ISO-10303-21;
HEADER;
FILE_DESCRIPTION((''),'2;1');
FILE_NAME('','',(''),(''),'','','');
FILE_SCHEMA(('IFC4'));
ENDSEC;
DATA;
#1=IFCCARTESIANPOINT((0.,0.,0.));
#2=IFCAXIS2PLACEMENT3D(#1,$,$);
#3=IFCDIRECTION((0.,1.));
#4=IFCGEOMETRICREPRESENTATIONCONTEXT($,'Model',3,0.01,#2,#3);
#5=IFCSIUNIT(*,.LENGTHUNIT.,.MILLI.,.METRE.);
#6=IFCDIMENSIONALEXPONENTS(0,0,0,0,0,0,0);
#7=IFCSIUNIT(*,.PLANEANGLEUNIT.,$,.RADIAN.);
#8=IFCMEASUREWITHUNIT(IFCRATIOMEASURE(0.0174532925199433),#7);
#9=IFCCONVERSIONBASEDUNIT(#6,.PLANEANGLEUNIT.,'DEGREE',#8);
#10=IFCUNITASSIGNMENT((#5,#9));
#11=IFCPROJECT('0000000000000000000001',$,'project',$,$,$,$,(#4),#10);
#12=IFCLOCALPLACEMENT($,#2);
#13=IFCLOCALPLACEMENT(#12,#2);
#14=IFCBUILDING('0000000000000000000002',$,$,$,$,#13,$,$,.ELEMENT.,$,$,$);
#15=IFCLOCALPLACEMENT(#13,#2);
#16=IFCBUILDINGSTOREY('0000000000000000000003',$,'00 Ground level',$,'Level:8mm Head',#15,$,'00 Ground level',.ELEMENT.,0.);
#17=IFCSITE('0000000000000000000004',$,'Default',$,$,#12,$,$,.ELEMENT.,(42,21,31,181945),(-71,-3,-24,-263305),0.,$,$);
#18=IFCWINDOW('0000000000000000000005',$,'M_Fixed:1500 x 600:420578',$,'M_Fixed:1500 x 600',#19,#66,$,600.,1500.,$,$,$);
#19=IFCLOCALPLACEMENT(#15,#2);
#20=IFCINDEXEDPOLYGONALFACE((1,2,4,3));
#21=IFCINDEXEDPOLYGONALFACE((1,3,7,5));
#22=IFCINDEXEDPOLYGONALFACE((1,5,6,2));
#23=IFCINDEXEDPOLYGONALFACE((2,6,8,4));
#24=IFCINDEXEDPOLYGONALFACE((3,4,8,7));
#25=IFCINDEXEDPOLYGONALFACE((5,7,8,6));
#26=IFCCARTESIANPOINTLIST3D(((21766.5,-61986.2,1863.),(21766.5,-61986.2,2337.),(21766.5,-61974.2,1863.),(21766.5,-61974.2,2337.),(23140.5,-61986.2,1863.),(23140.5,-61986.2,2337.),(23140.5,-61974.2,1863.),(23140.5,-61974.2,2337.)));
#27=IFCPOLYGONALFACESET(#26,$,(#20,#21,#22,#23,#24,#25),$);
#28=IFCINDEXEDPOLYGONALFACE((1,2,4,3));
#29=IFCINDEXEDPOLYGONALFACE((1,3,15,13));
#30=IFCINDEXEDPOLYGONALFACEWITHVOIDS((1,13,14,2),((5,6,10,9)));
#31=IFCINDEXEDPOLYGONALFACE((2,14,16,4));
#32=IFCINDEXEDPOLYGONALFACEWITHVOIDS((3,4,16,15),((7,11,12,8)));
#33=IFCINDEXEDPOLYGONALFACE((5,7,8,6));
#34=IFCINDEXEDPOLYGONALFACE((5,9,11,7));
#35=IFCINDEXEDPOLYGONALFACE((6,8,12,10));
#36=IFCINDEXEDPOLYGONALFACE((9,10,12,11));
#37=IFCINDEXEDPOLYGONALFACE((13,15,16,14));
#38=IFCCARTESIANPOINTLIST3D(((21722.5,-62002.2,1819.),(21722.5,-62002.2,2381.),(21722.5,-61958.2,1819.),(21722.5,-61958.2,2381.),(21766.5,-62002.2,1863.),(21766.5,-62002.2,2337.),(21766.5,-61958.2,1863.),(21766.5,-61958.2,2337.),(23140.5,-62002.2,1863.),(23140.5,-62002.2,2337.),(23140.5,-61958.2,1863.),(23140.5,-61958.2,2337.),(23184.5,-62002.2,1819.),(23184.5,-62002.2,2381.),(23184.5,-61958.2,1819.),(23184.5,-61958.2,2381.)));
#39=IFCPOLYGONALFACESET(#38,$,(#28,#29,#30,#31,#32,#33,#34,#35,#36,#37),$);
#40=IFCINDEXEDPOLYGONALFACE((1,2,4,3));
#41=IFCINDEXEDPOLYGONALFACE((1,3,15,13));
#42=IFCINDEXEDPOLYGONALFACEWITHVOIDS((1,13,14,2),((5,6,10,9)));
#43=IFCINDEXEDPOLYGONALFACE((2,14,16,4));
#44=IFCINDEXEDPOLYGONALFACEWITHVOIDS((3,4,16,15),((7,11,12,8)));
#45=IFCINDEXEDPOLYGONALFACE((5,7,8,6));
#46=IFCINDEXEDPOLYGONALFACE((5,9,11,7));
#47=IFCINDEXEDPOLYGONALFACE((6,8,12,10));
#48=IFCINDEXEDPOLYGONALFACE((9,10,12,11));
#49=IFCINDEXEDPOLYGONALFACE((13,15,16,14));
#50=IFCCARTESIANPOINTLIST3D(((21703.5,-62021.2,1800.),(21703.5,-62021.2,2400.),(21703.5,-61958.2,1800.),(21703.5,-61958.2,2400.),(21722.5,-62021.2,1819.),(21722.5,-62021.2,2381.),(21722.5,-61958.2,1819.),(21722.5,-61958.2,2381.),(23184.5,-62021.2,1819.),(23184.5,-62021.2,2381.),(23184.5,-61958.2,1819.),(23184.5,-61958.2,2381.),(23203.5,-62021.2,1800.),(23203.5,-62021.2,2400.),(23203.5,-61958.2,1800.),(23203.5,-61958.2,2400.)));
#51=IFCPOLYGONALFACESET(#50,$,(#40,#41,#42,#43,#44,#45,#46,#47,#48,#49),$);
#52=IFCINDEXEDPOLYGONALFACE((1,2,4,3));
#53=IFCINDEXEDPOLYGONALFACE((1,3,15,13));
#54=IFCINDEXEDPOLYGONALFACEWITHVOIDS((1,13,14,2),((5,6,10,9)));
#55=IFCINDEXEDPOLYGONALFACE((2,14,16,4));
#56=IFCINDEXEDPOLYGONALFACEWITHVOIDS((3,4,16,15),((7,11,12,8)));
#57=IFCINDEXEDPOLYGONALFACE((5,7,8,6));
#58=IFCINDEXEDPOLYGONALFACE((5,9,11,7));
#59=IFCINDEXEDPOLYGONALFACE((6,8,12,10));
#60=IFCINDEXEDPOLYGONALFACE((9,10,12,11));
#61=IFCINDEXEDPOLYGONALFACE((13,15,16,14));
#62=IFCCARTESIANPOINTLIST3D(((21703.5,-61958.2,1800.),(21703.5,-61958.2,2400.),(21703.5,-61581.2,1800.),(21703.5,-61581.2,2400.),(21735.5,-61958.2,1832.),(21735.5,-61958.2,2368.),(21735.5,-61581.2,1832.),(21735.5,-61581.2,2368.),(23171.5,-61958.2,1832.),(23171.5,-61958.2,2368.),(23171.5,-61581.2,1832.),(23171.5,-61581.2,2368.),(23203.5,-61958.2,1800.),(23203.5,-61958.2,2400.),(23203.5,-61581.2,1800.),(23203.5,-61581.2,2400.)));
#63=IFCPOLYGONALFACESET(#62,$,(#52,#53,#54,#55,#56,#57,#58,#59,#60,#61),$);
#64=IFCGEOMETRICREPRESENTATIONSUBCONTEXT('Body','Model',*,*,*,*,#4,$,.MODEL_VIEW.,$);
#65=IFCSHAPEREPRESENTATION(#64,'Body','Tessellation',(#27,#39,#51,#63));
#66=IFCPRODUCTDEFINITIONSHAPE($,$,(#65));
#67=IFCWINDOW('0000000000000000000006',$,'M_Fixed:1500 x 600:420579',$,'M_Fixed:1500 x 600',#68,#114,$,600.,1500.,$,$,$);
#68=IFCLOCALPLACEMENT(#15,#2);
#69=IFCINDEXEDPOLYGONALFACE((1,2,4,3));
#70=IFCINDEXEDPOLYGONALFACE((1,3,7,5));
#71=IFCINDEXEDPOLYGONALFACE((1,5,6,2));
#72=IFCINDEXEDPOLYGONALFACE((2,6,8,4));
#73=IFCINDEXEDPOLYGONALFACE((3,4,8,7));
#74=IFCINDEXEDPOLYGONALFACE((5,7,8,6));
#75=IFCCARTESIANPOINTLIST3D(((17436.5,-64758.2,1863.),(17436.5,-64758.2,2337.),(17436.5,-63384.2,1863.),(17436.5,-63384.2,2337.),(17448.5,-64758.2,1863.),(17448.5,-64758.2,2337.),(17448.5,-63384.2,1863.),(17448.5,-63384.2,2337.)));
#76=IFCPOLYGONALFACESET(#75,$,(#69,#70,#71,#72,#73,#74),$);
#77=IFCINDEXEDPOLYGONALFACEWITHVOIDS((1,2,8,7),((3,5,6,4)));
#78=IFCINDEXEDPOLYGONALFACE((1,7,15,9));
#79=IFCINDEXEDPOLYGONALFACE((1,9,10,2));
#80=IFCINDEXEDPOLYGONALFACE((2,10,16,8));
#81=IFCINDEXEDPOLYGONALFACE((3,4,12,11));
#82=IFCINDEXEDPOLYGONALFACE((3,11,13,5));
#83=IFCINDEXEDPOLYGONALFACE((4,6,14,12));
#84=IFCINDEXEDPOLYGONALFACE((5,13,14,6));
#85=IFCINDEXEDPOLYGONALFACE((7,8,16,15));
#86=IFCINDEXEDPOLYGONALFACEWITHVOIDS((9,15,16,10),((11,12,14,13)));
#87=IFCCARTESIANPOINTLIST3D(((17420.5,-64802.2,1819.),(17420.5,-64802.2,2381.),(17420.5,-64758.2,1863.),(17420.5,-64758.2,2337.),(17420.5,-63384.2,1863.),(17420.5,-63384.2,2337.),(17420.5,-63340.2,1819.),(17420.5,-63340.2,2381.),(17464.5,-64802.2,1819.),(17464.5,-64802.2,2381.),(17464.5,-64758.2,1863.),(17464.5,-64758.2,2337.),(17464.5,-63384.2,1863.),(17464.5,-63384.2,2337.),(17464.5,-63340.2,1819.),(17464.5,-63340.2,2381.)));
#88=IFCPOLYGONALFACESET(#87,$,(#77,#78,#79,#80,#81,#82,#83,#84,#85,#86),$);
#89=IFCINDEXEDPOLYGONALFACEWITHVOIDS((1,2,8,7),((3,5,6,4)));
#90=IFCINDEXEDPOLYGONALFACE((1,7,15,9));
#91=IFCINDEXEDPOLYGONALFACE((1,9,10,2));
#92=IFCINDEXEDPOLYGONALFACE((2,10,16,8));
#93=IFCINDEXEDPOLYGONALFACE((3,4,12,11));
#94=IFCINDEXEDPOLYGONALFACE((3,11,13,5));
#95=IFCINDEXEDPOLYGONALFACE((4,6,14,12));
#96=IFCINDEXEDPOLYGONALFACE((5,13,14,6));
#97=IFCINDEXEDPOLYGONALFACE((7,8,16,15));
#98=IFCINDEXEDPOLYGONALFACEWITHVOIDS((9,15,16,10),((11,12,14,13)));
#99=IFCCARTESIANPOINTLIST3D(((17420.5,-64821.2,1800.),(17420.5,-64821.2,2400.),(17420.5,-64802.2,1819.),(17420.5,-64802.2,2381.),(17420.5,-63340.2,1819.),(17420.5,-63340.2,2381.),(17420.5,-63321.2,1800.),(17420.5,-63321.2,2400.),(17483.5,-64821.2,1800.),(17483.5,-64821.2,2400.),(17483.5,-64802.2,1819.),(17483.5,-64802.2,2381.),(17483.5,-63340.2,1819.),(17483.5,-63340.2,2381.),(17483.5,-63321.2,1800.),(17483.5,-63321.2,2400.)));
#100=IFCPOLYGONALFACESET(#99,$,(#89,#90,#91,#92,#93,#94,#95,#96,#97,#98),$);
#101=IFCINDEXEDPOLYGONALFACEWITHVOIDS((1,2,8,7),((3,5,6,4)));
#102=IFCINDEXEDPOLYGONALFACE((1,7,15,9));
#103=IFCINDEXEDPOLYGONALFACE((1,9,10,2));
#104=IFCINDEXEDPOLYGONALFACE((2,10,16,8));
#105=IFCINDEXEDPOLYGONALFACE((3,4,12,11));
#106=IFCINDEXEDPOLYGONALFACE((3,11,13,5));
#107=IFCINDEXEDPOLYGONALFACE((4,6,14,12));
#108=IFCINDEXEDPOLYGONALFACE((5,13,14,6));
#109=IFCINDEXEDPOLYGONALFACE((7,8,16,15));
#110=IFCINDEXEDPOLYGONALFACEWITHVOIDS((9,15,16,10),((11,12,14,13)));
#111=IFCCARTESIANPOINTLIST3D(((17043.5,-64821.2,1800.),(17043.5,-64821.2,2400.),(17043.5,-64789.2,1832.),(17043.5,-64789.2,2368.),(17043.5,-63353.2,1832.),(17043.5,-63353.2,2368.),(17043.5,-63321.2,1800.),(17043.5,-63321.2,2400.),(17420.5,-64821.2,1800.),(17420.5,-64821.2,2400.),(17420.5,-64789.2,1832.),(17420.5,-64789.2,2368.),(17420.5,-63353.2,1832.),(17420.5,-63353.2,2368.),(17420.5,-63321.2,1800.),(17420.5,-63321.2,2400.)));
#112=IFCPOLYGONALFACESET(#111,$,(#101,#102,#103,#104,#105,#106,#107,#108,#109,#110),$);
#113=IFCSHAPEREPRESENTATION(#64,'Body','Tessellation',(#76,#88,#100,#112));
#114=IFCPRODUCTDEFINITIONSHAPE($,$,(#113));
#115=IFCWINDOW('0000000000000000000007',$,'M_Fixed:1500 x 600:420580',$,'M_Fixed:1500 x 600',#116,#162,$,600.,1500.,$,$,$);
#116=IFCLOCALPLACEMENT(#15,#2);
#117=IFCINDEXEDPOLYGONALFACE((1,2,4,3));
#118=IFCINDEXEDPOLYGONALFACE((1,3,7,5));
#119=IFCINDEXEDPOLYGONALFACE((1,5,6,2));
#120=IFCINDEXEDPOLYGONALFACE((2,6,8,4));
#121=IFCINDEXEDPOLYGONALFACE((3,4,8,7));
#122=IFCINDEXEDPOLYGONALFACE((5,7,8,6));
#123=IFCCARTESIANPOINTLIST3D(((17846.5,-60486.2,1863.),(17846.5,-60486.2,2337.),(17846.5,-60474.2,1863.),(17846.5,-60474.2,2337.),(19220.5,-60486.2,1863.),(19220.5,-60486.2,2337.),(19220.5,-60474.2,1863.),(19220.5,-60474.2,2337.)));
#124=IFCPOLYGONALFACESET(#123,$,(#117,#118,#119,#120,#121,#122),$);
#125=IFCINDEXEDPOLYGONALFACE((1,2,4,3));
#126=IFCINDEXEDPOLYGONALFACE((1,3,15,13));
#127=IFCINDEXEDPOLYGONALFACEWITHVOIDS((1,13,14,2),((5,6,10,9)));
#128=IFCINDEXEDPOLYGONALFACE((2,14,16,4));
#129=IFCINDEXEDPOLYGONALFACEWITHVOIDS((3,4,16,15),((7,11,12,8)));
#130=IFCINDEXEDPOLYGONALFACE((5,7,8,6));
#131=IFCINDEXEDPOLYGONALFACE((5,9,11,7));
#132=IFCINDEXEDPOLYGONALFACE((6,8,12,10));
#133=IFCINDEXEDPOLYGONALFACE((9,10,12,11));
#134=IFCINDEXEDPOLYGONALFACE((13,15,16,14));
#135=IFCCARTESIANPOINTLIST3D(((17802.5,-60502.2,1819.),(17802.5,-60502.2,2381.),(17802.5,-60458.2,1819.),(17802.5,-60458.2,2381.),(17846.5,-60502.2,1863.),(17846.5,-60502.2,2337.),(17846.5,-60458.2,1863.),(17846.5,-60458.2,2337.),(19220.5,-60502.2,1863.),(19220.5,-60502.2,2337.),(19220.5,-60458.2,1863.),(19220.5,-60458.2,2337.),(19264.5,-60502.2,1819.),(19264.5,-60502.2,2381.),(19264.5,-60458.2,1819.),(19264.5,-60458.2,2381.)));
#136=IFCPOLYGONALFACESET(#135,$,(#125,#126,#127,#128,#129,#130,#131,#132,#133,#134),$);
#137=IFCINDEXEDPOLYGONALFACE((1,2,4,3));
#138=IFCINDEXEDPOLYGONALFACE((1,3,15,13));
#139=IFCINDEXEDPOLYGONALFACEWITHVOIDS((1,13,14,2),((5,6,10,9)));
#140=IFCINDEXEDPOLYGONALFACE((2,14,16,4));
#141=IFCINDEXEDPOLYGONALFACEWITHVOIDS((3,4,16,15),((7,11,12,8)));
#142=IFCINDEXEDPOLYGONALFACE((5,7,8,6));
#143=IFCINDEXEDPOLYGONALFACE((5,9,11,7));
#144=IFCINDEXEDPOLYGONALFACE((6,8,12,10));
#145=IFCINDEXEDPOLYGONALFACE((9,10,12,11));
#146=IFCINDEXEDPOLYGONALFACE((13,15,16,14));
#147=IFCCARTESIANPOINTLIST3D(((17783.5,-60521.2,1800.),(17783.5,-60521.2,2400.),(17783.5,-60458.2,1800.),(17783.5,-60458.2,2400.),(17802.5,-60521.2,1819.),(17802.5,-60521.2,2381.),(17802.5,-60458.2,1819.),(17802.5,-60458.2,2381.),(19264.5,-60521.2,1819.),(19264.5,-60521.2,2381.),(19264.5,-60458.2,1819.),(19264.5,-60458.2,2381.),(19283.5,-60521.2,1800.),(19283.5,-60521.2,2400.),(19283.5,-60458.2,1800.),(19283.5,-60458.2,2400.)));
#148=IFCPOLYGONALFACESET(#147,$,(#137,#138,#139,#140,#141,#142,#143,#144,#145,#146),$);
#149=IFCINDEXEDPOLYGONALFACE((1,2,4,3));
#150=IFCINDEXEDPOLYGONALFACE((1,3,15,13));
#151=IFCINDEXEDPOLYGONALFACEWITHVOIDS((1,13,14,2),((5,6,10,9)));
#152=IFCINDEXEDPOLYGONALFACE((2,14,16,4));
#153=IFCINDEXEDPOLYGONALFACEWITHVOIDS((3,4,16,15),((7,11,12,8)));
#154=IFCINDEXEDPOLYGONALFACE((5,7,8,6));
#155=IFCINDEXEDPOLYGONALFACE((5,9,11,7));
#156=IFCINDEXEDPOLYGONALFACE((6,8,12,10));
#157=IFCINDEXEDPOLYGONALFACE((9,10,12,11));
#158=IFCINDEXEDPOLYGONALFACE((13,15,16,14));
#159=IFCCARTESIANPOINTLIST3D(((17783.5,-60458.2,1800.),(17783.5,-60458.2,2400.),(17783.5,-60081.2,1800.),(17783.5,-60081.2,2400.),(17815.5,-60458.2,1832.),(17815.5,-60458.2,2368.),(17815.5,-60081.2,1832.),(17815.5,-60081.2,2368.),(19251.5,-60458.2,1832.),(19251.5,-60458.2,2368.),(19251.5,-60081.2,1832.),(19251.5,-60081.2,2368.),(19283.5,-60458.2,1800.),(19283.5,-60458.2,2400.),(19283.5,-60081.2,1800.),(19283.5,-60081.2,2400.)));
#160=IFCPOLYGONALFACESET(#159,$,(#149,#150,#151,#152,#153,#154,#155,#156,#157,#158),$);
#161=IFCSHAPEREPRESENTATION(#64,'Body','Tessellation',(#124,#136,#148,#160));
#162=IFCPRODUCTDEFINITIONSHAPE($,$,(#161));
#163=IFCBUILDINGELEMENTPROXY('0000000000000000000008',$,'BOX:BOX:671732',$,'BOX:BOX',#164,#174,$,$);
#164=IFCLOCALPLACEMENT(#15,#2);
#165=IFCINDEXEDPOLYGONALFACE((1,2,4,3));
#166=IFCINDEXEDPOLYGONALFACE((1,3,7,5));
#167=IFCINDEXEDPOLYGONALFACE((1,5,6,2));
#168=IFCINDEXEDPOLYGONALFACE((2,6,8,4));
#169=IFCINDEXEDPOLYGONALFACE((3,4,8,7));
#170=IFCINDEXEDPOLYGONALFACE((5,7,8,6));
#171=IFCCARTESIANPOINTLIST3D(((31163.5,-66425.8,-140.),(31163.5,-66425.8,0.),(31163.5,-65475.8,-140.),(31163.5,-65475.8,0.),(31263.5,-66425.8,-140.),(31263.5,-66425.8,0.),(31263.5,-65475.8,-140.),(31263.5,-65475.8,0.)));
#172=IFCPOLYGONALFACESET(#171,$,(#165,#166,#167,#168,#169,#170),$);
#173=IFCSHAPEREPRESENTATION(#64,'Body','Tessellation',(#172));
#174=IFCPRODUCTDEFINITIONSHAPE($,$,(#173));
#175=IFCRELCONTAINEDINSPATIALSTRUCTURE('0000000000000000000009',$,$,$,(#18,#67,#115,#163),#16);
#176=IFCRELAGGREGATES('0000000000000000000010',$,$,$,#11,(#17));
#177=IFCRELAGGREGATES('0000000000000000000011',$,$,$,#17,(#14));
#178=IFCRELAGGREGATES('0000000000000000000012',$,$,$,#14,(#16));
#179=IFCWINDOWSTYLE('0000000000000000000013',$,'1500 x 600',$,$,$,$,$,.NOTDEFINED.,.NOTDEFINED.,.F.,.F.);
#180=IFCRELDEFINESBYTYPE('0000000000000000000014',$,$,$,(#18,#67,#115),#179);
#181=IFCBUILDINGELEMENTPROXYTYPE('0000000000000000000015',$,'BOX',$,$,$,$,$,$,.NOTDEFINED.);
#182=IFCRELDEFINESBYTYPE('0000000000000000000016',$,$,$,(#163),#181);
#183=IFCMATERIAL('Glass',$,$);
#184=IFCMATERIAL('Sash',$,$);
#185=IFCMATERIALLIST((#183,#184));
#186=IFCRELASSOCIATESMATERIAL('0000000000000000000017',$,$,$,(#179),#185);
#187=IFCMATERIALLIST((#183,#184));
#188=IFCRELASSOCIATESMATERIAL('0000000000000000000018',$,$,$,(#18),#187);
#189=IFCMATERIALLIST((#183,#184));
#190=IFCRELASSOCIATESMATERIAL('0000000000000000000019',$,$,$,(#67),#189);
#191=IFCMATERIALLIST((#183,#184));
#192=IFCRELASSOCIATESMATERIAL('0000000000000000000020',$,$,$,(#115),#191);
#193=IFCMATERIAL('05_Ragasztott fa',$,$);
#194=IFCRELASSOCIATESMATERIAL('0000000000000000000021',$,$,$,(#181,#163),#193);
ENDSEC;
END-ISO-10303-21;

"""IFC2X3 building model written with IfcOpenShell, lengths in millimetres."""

from ifc_helpers import new_model, entity, si_unit, converted_unit, direction, frame, frame_2d, origin, origin_2d_with_axis, place, context, subcontext, project, spatial, polyline, rectangle, outline, extrude, source, transform, mapped, material, material_list, type_object, type_shapes, element, save


model = new_model("IFC2X3")

# Units and contexts
model_context = context("Model", 3, precision=0.01, world=origin(), true_north=direction((0.0, 1.0)))
body_context = subcontext(model_context, "Body", "Model", "MODEL_VIEW")
ifc_project = project(units=[si_unit("LENGTHUNIT", "METRE", prefix="MILLI"), converted_unit("PLANEANGLEUNIT", "DEGREE", entity("IfcRatioMeasure", 0.0174532925199433), si_unit("PLANEANGLEUNIT", "RADIAN"), dimensions=[0, 0, 0, 0, 0, 0, 0])], contexts=[model_context])

# Site, building, storey
site_placement = place(None, origin())
site = spatial("IfcSite", under=ifc_project, at=site_placement, Name="Default", CompositionType="ELEMENT", RefLatitude=(42, 21, 31, 181945), RefLongitude=(-71, -3, -24, -263305), RefElevation=0.0)
building_placement = place(site_placement, origin())
building = spatial("IfcBuilding", under=site, at=building_placement, CompositionType="ELEMENT")
storey_placement = place(building_placement, origin())
storey = spatial("IfcBuildingStorey", under=building, at=storey_placement, Name="00 Ground level", ObjectType="Level:8mm Head", LongName="00 Ground level", CompositionType="ELEMENT", Elevation=0.0)

# Windows
ifc_material_1 = material(Name="Glass")
ifc_material_2 = material(Name="Sash")
ifc_material_list_1 = material_list([ifc_material_1, ifc_material_2])
window_style_1 = type_object("IfcWindowStyle", Name="1500 x 600", ConstructionType="NOTDEFINED", OperationType="NOTDEFINED", ParameterTakesPrecedence=False, Sizeable=False, material=ifc_material_list_1)
shared_shape_1 = source(origin(), body_context, "Body", "SweptSolid", [
    extrude(rectangle(XDim=1374.0, YDim=12.0, at=origin_2d_with_axis()), frame((750.0, 425.0, 63.0), z_axis=(0.0, 0.0, 1.0), x_axis=(-1.0, 0.0, 0.0)), (0.0, 0.0, 1.0), 474.0),
    extrude(outline(polyline([(-731.0, -281.0), (731.0, -281.0), (731.0, 281.0), (-731.0, 281.0), (-731.0, -281.0)]), holes=[polyline([(-687.0, -237.0), (-687.0, 237.0), (687.0, 237.0), (687.0, -237.0), (-687.0, -237.0)])]), frame((750.0, 447.0, 300.0), z_axis=(0.0, -1.0, 0.0), x_axis=(-1.0, 0.0, 0.0)), (0.0, 0.0, 1.0), 44.0),
    extrude(outline(polyline([(-750.0, -300.0), (750.0, -300.0), (750.0, 300.0), (-750.0, 300.0), (-750.0, -300.0)]), holes=[polyline([(-731.0, -281.0), (-731.0, 281.0), (731.0, 281.0), (731.0, -281.0), (-731.0, -281.0)])]), frame((750.0, 466.0, 300.0), z_axis=(0.0, -1.0, 0.0), x_axis=(-1.0, 0.0, 0.0)), (0.0, 0.0, 1.0), 63.0),
    extrude(outline(polyline([(-750.0, -300.0), (750.0, -300.0), (750.0, 300.0), (-750.0, 300.0), (-750.0, -300.0)]), holes=[polyline([(-718.0, -268.0), (-718.0, 268.0), (718.0, 268.0), (718.0, -268.0), (-718.0, -268.0)])]), frame((750.0, 403.0, 300.0), z_axis=(0.0, -1.0, 0.0), x_axis=(-1.0, 0.0, 0.0)), (0.0, 0.0, 1.0), 377.0),
])
type_shapes(window_style_1, [shared_shape_1])
ifc_material_list_2 = material_list([ifc_material_1, ifc_material_2])
window_1_placement = place(storey_placement, frame((23203.5, -61555.2, 1800.0), z_axis=(0.0, 0.0, 1.0), x_axis=(-1.0, 0.0, 0.0)))
element("IfcWindow", 1, at=window_1_placement, inside=storey, type_object=window_style_1, material=ifc_material_list_2, Name="M_Fixed:1500 x 600:420578", ObjectType="M_Fixed:1500 x 600", OverallHeight=600.0, OverallWidth=1500.0, context=body_context, shape_type="MappedRepresentation", body=[
    mapped(shared_shape_1, transform((0.0, 0.0, 0.0), scale=1.0)),
])
ifc_material_list_3 = material_list([ifc_material_1, ifc_material_2])
window_2_placement = place(storey_placement, frame((17017.5, -63321.2, 1800.0), z_axis=(0.0, 0.0, 1.0), x_axis=(0.0, -1.0, 0.0)))
element("IfcWindow", 2, at=window_2_placement, inside=storey, type_object=window_style_1, material=ifc_material_list_3, Name="M_Fixed:1500 x 600:420579", ObjectType="M_Fixed:1500 x 600", OverallHeight=600.0, OverallWidth=1500.0, context=body_context, shape_type="MappedRepresentation", body=[
    mapped(shared_shape_1, transform((0.0, 0.0, 0.0), scale=1.0)),
])
ifc_material_list_4 = material_list([ifc_material_1, ifc_material_2])
window_3_placement = place(storey_placement, frame((19283.5, -60055.2, 1800.0), z_axis=(0.0, 0.0, 1.0), x_axis=(-1.0, 0.0, 0.0)))
element("IfcWindow", 3, at=window_3_placement, inside=storey, type_object=window_style_1, material=ifc_material_list_4, Name="M_Fixed:1500 x 600:420580", ObjectType="M_Fixed:1500 x 600", OverallHeight=600.0, OverallWidth=1500.0, context=body_context, shape_type="MappedRepresentation", body=[
    mapped(shared_shape_1, transform((0.0, 0.0, 0.0), scale=1.0)),
])

# Building element proxy
ifc_material_3 = material(Name="05_Ragasztott fa")
building_element_proxy_type = type_object("IfcBuildingElementProxyType", Name="BOX", PredefinedType="NOTDEFINED", material=ifc_material_3)
shared_shape_2 = source(origin(), body_context, "Body", "SweptSolid", [
    extrude(rectangle(XDim=100.0, YDim=950.0, at=frame_2d((0.0, 0.0), x_axis=(1.0, 0.0))), frame((50.0, 475.0, 0.0), z_axis=(0.0, 0.0, 1.0), x_axis=(-1.0, 0.0, 0.0)), (0.0, 0.0, 1.0), 140.0),
])
type_shapes(building_element_proxy_type, [shared_shape_2])
proxy_placement = place(storey_placement, frame((31163.5, -66425.8, -140.0)))
element("IfcBuildingElementProxy", 4, at=proxy_placement, inside=storey, type_object=building_element_proxy_type, material=ifc_material_3, Name="BOX:BOX:671732", ObjectType="BOX:BOX", context=body_context, shape_type="MappedRepresentation", body=[
    mapped(shared_shape_2, transform((0.0, 0.0, 0.0), scale=1.0)),
])

save(model, "model.ifc")
